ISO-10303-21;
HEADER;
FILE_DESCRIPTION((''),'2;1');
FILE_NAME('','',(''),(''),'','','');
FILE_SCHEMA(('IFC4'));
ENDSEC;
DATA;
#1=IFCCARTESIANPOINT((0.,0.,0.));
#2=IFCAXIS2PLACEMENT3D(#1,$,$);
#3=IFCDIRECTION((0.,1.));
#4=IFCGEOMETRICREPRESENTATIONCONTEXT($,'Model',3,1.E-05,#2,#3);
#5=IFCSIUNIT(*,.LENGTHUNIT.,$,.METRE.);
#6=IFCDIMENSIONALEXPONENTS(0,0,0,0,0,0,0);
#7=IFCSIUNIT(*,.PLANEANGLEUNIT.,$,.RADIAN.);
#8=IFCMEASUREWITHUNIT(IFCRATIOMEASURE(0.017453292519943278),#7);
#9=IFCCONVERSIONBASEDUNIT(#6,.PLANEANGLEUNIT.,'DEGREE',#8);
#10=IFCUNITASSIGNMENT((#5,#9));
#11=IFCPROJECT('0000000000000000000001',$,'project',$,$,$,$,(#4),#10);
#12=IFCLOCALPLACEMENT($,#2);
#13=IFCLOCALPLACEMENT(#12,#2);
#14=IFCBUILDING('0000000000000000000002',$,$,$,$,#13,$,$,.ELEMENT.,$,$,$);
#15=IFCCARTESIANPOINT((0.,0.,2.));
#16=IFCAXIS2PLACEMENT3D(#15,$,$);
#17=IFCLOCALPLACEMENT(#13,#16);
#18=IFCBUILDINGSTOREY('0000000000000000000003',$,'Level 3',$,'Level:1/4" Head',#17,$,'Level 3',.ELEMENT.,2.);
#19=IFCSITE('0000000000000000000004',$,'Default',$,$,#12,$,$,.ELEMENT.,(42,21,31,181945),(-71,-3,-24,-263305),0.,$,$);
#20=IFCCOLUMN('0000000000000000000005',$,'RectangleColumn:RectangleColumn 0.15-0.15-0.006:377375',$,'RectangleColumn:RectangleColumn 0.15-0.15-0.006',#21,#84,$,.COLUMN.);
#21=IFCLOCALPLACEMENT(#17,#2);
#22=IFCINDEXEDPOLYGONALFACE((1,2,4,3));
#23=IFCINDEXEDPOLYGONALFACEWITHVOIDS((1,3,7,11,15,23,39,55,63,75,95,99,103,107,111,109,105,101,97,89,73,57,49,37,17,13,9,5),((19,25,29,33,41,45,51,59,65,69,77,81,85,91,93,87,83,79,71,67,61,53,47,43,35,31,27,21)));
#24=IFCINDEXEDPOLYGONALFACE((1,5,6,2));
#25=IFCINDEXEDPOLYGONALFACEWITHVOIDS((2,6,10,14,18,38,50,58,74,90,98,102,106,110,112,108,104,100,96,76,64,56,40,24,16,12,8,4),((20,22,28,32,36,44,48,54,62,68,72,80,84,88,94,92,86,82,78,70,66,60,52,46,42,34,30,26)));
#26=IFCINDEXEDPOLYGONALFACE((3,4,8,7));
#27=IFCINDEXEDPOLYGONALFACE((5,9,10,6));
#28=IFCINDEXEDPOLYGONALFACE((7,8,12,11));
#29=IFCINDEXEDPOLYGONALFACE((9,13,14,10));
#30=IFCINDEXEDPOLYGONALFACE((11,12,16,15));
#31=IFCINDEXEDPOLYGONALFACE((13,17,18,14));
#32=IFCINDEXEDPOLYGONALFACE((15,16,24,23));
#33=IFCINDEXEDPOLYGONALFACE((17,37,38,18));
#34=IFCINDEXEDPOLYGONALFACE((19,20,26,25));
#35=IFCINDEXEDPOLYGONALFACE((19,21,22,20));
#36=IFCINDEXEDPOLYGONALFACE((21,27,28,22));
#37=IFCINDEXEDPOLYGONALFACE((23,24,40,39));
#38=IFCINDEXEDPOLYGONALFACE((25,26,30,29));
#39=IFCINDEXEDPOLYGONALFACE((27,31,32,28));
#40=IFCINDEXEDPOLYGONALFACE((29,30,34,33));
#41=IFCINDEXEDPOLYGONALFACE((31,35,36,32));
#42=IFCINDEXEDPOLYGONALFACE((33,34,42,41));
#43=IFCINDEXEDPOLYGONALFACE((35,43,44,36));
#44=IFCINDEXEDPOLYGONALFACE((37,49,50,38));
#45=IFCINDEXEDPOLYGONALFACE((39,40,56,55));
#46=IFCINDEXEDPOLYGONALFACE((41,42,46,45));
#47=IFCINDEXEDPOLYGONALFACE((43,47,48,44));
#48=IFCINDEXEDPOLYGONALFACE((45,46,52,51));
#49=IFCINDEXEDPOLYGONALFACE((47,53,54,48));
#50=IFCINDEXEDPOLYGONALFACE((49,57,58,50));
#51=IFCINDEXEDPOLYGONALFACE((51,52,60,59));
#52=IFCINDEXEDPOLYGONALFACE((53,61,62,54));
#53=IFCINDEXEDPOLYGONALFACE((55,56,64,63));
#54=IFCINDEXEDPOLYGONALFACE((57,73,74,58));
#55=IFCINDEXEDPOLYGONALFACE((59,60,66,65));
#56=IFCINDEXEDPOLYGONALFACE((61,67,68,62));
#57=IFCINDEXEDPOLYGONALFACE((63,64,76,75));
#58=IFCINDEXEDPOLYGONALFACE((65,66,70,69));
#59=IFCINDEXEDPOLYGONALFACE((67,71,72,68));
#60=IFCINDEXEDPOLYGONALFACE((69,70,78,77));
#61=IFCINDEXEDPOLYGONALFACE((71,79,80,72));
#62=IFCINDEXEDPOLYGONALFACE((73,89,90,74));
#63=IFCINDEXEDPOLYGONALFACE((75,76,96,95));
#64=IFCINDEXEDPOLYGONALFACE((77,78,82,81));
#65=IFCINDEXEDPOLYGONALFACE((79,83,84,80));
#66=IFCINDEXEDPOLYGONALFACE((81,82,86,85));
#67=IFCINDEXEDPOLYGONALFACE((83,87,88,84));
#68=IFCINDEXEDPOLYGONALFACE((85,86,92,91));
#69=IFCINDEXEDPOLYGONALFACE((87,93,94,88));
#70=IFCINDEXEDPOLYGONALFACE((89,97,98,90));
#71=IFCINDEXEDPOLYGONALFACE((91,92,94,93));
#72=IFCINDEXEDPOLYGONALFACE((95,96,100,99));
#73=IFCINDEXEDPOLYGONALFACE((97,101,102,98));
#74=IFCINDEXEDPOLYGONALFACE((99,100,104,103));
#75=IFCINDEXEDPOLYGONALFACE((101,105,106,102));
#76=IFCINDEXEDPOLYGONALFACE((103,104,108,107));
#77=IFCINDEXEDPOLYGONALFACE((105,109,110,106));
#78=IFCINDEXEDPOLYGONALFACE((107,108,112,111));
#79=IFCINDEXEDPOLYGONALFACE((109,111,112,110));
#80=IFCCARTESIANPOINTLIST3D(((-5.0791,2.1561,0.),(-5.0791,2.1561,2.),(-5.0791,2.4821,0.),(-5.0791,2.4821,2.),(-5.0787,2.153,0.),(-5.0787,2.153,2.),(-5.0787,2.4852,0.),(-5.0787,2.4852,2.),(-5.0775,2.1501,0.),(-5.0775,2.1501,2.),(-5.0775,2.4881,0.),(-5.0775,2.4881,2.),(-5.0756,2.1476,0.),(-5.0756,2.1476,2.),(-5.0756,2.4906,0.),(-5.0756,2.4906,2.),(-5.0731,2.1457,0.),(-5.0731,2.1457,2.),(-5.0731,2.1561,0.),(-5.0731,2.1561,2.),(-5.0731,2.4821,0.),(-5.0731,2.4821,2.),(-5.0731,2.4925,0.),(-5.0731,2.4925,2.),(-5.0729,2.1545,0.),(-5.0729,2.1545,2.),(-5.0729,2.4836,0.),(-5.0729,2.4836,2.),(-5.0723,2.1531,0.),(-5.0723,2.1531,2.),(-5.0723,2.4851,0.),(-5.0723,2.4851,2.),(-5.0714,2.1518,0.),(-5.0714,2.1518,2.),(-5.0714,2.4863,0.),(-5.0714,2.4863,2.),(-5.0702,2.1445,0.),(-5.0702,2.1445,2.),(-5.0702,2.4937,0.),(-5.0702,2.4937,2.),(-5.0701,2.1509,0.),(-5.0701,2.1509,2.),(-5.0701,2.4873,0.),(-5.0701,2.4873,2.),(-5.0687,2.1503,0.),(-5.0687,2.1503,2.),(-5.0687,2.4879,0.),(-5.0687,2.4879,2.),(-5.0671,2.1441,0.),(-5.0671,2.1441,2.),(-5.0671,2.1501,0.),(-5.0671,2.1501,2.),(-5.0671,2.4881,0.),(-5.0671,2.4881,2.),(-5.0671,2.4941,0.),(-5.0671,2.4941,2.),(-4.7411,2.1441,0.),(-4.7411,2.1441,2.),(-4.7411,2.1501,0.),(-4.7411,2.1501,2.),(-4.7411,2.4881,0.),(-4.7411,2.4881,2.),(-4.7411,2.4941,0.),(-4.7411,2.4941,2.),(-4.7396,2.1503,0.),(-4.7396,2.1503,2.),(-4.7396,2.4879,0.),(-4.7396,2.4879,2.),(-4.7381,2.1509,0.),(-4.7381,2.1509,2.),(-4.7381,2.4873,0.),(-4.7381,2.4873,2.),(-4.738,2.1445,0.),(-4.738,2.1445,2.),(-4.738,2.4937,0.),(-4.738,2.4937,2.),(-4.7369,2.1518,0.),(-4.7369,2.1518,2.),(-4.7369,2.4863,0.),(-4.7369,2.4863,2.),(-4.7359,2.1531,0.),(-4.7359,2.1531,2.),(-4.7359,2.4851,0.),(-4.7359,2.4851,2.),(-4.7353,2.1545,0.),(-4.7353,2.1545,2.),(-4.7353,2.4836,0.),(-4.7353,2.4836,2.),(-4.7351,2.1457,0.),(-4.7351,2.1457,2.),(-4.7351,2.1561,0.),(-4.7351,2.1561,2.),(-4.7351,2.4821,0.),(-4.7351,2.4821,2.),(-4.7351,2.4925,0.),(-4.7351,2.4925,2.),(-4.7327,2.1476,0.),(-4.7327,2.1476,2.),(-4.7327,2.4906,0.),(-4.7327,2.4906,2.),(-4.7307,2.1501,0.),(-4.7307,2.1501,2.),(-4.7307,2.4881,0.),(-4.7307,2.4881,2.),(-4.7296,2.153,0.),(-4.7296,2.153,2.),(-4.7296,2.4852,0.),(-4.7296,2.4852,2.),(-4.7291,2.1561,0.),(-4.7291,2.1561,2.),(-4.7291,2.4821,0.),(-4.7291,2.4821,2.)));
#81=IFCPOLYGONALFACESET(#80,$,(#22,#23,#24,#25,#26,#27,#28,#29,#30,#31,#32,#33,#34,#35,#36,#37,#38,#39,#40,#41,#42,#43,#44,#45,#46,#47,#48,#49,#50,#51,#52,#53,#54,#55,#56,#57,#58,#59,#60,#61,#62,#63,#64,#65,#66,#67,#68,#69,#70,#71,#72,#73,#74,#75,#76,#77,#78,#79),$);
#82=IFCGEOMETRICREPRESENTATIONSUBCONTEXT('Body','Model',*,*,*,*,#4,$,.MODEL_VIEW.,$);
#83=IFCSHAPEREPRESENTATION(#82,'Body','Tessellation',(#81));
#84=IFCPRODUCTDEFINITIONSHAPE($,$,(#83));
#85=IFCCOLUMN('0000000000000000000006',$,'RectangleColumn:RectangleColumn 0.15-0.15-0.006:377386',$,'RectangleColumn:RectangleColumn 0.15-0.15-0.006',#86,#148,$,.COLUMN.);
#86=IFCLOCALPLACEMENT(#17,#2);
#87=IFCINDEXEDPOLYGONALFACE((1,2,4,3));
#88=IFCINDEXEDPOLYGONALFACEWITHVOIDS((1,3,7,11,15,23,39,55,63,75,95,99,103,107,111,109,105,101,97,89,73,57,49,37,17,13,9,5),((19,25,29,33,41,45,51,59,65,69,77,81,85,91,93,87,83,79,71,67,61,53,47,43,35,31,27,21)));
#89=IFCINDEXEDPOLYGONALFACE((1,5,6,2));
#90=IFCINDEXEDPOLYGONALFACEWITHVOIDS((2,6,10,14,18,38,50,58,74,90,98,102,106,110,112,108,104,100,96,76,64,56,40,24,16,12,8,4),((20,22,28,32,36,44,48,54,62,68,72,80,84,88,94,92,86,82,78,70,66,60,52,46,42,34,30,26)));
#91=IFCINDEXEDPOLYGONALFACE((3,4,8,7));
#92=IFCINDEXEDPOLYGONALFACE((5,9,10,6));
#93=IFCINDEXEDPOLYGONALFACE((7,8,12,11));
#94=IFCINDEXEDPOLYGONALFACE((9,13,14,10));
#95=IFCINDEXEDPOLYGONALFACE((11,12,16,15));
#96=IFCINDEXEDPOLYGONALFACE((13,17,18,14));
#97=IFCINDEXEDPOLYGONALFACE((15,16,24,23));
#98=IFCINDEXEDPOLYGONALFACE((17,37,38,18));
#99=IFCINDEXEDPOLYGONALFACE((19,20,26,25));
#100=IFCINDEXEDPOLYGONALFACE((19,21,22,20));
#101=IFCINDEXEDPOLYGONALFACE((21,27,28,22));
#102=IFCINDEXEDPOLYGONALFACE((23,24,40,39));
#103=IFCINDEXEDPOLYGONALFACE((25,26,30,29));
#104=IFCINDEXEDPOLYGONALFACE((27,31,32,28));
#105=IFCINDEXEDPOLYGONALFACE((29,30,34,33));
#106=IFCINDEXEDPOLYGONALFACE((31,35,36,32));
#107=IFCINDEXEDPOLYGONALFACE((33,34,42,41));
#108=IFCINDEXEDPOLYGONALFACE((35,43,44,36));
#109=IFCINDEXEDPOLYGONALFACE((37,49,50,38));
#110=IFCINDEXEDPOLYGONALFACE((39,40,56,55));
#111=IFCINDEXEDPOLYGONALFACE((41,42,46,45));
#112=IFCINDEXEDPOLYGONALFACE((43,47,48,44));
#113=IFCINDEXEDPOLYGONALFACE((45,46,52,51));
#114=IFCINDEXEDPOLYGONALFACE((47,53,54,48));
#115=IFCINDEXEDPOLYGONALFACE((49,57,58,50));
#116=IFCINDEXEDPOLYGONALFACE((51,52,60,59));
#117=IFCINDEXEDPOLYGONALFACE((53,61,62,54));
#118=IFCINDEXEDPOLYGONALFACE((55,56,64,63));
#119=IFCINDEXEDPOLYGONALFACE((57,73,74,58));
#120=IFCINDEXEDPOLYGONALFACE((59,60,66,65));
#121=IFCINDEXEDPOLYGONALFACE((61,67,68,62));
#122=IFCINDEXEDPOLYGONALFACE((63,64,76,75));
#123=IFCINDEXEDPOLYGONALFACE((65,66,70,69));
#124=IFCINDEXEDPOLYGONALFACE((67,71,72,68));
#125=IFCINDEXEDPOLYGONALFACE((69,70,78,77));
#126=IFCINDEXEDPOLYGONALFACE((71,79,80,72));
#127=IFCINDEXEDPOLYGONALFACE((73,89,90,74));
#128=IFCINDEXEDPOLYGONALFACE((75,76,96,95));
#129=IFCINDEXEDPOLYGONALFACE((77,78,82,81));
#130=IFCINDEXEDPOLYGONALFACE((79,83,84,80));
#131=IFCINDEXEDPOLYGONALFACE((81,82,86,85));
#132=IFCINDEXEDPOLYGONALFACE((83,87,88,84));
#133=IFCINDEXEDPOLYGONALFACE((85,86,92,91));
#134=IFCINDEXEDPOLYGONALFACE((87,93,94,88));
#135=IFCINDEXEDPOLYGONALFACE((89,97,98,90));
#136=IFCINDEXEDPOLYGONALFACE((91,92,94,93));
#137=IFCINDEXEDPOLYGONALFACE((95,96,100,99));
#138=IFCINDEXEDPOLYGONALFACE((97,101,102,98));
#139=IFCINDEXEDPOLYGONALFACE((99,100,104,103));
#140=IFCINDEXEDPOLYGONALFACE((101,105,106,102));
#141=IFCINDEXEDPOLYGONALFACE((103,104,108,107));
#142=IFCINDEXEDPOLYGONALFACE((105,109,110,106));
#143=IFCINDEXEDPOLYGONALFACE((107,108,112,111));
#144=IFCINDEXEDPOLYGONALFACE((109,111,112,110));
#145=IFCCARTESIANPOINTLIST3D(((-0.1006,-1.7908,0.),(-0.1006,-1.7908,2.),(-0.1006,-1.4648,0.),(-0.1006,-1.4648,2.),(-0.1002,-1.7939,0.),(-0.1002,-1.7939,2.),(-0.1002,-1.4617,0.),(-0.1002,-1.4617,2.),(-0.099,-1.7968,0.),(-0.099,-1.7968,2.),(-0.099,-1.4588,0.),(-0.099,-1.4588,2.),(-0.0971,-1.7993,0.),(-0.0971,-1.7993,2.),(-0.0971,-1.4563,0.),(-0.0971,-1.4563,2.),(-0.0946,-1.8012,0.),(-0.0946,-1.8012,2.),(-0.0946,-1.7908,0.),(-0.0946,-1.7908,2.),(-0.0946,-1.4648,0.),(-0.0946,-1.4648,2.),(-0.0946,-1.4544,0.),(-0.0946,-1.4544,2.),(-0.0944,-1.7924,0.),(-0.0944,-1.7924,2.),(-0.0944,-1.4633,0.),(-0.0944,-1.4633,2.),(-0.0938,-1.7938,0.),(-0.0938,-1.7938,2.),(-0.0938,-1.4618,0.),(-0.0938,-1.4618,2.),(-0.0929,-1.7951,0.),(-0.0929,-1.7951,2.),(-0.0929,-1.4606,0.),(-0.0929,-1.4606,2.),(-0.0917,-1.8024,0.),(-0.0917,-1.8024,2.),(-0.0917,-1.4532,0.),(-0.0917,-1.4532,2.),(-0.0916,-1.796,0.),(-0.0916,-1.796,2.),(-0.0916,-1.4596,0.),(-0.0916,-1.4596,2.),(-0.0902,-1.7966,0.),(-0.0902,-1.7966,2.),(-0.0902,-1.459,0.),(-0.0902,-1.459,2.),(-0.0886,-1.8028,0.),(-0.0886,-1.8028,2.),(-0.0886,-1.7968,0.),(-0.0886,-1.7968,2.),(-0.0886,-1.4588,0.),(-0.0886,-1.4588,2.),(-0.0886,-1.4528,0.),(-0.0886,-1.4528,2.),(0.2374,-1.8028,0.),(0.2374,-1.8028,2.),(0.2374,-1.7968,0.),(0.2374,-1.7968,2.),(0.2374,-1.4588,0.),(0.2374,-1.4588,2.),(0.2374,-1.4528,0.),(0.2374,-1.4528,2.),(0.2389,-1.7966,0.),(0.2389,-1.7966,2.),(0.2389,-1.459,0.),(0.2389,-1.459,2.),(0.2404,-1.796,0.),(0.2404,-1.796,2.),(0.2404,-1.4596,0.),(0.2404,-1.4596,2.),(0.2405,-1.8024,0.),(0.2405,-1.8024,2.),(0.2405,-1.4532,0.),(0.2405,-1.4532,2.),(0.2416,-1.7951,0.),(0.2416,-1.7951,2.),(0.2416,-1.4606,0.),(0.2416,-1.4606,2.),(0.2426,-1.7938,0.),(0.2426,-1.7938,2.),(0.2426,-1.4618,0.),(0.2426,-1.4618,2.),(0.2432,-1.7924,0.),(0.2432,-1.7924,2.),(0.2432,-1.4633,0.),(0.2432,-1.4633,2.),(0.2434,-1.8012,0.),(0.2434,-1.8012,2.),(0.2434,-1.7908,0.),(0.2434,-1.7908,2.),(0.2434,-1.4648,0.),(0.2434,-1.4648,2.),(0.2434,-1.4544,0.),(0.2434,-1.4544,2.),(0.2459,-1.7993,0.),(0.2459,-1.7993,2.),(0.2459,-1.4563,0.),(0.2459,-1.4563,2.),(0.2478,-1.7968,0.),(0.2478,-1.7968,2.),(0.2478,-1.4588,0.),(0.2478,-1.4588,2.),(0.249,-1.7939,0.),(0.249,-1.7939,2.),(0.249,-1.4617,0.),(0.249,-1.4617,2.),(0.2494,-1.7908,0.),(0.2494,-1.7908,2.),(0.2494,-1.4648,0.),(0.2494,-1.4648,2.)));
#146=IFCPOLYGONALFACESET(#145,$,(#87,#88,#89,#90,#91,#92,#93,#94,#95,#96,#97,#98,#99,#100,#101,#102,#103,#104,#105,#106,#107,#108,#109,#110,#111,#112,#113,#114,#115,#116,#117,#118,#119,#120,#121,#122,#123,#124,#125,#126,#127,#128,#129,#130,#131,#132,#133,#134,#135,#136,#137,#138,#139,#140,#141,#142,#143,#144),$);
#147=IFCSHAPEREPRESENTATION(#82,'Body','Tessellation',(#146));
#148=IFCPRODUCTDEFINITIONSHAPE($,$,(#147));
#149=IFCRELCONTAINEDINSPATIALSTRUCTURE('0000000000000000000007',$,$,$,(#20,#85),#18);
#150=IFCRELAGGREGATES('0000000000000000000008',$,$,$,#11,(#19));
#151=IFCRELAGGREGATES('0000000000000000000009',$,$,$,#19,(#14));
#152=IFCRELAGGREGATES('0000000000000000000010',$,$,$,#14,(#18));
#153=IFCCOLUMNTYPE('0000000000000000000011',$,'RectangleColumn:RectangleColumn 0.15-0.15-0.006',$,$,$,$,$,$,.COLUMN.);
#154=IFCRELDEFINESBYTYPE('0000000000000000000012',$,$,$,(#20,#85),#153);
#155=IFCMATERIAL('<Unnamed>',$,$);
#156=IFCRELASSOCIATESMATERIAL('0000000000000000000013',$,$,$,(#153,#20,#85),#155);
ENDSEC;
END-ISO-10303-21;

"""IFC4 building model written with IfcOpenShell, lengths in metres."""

from ifc_helpers import new_model, entity, si_unit, converted_unit, direction, frame, origin, place, context, subcontext, project, spatial, line, arc, indexed_curve, outline, extrude, source, transform, mapped, material, type_object, type_shapes, element, save


model = new_model("IFC4")

# Units and contexts
model_context = context("Model", 3, precision=1e-05, world=origin(), true_north=direction((0.0, 1.0)))
body_context = subcontext(model_context, "Body", "Model", "MODEL_VIEW")
ifc_project = project(units=[si_unit("LENGTHUNIT", "METRE"), converted_unit("PLANEANGLEUNIT", "DEGREE", entity("IfcRatioMeasure", 0.017453292519943278), si_unit("PLANEANGLEUNIT", "RADIAN"), dimensions=[0, 0, 0, 0, 0, 0, 0])], contexts=[model_context])

# Site, building, storey
site_placement = place(None, origin())
site = spatial("IfcSite", under=ifc_project, at=site_placement, Name="Default", CompositionType="ELEMENT", RefLatitude=(42, 21, 31, 181945), RefLongitude=(-71, -3, -24, -263305), RefElevation=0.0)
building_placement = place(site_placement, origin())
building = spatial("IfcBuilding", under=site, at=building_placement, CompositionType="ELEMENT")
storey_placement = place(building_placement, frame((0.0, 0.0, 2.0)))
storey = spatial("IfcBuildingStorey", under=building, at=storey_placement, Name="Level 3", ObjectType="Level:1/4\" Head", LongName="Level 3", CompositionType="ELEMENT", Elevation=2.0)

# Columns
ifc_material_1 = material(Name="<Unnamed>")
column_type = type_object("IfcColumnType", Name="RectangleColumn:RectangleColumn 0.15-0.15-0.006", PredefinedType="COLUMN", material=ifc_material_1)
shared_shape = source(origin(), body_context, "Body", "SweptSolid", [
    extrude(outline(indexed_curve([(-0.163, -0.175), (0.163, -0.175), (0.1715, -0.1715), (0.175, -0.163), (0.175, 0.163), (0.1715, 0.1715), (0.163, 0.175), (-0.163, 0.175), (-0.1715, 0.1715), (-0.175, 0.163), (-0.175, -0.163), (-0.1715, -0.1715)], segments=[line(1, 2), arc(2, 3, 4), line(4, 5), arc(5, 6, 7), line(7, 8), arc(8, 9, 10), line(10, 11), arc(11, 12, 1)], self_intersect=False), holes=[indexed_curve([(-0.163, -0.169), (-0.1672, -0.1672), (-0.169, -0.163), (-0.169, 0.163), (-0.1672, 0.1672), (-0.163, 0.169), (0.163, 0.169), (0.1672, 0.1672), (0.169, 0.163), (0.169, -0.163), (0.1672, -0.1672), (0.163, -0.169)], segments=[arc(1, 2, 3), line(3, 4), arc(4, 5, 6), line(6, 7), arc(7, 8, 9), line(9, 10), arc(10, 11, 12), line(12, 1)], self_intersect=False)]), frame((0.0, 0.0, 2.0), z_axis=(0.0, 0.0, 1.0), x_axis=(-1.0, 0.0, 0.0)), (0.0, 0.0, 1.0), 2.0),
])
type_shapes(column_type, [shared_shape])
for number, where, name in (
    (1, (-4.9041, 2.3191, -2.0), "RectangleColumn:RectangleColumn 0.15-0.15-0.006:377375"),
    (2, (0.0744, -1.6278, -2.0), "RectangleColumn:RectangleColumn 0.15-0.15-0.006:377386"),
):
    element("IfcColumn", number, at=place(storey_placement, frame(where)), inside=storey, type_object=column_type, material=ifc_material_1, Name=name, ObjectType="RectangleColumn:RectangleColumn 0.15-0.15-0.006", PredefinedType="COLUMN", context=body_context, shape_type="MappedRepresentation", body=[
        mapped(shared_shape, transform((0.0, 0.0, 0.0), scale=1.0)),
    ])

save(model, "model.ifc")
